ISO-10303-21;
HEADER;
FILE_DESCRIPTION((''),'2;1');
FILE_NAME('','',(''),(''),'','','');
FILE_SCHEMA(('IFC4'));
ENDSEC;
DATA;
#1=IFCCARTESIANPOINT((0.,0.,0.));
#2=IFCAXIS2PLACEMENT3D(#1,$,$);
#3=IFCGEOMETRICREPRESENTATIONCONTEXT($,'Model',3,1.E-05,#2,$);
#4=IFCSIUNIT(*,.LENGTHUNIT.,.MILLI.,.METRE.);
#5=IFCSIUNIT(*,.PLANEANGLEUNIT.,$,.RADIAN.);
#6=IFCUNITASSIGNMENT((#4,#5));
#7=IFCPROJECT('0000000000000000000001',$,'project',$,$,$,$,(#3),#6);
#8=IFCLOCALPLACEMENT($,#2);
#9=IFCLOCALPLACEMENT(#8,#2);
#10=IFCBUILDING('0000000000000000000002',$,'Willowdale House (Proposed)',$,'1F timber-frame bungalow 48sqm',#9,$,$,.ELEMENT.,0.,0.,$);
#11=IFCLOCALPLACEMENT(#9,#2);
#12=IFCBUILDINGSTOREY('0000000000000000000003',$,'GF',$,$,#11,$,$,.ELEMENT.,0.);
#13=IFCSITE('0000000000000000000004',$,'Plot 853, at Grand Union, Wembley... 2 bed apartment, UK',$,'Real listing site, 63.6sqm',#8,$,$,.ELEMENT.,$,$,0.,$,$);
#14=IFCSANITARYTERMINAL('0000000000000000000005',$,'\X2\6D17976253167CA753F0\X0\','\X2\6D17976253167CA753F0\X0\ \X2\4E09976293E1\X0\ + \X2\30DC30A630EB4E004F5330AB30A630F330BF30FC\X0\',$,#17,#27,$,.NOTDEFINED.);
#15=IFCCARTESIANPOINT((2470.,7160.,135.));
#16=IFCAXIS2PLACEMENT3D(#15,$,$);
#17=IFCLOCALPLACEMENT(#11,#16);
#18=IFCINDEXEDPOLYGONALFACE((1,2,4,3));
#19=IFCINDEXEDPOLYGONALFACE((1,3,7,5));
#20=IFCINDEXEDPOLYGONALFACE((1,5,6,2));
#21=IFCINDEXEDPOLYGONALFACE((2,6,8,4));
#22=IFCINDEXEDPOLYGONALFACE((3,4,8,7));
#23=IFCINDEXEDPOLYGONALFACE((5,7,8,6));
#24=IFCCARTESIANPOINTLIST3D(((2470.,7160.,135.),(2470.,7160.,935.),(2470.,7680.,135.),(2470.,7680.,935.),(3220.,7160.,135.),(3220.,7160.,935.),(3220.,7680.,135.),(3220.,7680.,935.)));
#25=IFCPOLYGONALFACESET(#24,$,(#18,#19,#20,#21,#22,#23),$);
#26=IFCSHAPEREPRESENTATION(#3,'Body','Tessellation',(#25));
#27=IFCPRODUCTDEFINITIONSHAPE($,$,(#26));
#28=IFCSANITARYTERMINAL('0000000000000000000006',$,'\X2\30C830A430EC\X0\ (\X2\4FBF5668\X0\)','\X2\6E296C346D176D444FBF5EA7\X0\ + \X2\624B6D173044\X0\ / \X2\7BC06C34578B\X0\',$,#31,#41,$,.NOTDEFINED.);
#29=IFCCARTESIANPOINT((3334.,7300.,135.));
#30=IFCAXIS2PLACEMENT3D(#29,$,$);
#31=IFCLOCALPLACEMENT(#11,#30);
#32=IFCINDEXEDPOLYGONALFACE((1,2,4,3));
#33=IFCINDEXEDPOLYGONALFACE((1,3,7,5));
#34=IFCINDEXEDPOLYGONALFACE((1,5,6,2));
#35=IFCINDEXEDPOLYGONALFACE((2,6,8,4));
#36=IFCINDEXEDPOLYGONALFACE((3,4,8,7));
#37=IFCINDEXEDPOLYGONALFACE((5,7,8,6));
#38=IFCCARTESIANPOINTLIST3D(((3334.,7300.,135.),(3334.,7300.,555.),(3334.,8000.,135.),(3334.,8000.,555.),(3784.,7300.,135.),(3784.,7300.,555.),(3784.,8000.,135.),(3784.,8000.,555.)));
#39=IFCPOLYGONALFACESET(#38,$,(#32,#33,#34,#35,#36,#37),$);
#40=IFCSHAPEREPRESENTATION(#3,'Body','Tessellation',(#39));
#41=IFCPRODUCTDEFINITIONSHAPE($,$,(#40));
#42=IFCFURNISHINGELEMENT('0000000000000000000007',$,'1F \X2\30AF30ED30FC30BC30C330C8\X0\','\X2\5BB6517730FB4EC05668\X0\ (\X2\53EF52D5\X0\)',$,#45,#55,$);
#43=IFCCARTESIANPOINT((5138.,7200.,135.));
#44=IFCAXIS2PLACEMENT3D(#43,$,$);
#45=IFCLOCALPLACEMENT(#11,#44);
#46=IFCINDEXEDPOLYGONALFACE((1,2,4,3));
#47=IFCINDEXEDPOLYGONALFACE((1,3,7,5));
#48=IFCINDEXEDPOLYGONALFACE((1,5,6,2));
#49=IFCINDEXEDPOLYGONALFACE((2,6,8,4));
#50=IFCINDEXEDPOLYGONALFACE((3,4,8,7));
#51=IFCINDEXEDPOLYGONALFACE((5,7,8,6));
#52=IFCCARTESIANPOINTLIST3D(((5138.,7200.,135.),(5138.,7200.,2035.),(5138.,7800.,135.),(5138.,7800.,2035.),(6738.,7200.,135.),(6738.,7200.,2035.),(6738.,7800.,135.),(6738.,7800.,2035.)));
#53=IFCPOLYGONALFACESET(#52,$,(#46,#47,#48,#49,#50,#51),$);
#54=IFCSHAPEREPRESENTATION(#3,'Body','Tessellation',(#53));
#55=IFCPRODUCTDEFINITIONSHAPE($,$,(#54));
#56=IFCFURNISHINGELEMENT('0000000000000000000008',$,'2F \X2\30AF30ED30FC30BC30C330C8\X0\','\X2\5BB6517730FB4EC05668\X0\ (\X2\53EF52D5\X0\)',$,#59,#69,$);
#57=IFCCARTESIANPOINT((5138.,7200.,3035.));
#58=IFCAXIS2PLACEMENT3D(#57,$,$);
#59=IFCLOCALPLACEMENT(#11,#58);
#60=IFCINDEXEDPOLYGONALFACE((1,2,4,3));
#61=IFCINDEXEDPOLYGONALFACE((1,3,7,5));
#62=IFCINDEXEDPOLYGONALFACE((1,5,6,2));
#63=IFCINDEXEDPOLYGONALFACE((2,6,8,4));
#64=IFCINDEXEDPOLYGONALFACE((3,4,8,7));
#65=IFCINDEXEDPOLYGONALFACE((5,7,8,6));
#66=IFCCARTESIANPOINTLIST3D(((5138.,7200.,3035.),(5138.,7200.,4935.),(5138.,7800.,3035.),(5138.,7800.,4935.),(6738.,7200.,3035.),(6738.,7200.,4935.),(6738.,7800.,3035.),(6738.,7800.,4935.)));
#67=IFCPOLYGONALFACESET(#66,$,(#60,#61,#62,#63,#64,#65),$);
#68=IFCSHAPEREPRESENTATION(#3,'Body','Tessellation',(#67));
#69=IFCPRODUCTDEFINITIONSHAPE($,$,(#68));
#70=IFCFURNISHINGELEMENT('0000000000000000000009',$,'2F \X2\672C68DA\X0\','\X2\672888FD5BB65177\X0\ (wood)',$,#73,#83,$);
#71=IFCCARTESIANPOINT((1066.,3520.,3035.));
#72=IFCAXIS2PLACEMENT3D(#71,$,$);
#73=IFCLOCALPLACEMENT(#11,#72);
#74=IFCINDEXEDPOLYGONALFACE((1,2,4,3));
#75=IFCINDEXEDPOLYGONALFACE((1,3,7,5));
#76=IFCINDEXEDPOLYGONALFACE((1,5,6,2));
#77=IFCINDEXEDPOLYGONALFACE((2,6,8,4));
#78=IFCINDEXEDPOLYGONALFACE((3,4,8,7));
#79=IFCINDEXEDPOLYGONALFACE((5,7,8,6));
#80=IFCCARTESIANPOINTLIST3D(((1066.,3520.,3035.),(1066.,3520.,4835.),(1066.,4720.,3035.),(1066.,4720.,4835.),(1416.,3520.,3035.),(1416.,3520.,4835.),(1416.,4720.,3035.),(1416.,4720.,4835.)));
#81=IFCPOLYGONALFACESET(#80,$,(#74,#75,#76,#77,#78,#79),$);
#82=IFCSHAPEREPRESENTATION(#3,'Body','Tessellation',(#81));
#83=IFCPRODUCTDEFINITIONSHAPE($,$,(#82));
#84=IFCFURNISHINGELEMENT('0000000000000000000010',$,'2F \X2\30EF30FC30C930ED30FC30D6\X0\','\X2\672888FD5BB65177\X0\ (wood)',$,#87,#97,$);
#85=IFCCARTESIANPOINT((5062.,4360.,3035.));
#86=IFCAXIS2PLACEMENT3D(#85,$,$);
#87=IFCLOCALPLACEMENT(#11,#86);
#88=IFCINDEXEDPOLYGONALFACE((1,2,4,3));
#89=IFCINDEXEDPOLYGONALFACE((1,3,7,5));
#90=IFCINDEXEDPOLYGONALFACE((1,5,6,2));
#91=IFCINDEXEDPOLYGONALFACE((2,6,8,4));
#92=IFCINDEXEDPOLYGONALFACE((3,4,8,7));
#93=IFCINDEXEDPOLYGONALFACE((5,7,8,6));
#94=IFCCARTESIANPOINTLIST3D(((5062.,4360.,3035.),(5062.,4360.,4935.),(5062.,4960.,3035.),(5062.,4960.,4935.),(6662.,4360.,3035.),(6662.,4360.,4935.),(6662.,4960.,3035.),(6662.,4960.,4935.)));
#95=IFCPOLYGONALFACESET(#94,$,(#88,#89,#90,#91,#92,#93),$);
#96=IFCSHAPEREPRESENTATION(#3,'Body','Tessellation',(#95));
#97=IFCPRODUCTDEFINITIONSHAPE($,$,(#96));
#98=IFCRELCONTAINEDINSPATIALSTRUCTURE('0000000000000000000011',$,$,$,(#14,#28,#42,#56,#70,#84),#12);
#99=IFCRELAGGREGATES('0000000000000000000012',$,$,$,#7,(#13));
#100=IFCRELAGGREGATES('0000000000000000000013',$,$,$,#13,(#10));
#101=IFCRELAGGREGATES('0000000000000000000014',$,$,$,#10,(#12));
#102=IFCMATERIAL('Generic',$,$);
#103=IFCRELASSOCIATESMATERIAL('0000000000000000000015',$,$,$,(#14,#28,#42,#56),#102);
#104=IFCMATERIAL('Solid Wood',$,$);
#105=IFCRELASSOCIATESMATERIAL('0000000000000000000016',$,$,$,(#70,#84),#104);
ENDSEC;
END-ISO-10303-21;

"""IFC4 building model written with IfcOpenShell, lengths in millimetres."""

from ifc_helpers import new_model, si_unit, frame, frame_2d, origin, place, context, project, spatial, rectangle, extrude, material, element, save


model = new_model("IFC4")

# Units and contexts
model_context = context("Model", 3, precision=1e-05, world=origin())
ifc_project = project(units=[si_unit("LENGTHUNIT", "METRE", prefix="MILLI"), si_unit("PLANEANGLEUNIT", "RADIAN")], contexts=[model_context])

# Site, building, storey
site_placement = place(None, origin())
site = spatial("IfcSite", under=ifc_project, at=site_placement, Name="Plot 853, at Grand Union, Wembley... 2 bed apartment, UK", ObjectType="Real listing site, 63.6sqm", CompositionType="ELEMENT", RefElevation=0.0)
building_placement = place(site_placement, origin())
building = spatial("IfcBuilding", under=site, at=building_placement, Name="Willowdale House (Proposed)", ObjectType="1F timber-frame bungalow 48sqm", CompositionType="ELEMENT", ElevationOfRefHeight=0.0, ElevationOfTerrain=0.0)
storey_placement = place(building_placement, origin())
storey = spatial("IfcBuildingStorey", under=building, at=storey_placement, Name="GF", CompositionType="ELEMENT", Elevation=0.0)

# Shared definitions
ifc_material_1 = material(Name="Solid Wood")

# Shared definitions
ifc_material_2 = material(Name="Generic")

# Sanitary terminals
sanitary_terminal_1_placement = place(storey_placement, frame((2470.0, 7160.0, 135.0)))
element("IfcSanitaryTerminal", 1, at=sanitary_terminal_1_placement, inside=storey, material=ifc_material_2, Name="洗面化粧台", Description="洗面化粧台 三面鏡 + ボウル一体カウンター", PredefinedType="NOTDEFINED", context=model_context, shape_type="SweptSolid", body=[
    extrude(rectangle(XDim=750.0, YDim=520.0, at=frame_2d((375.0, 260.0))), frame((2470.0, 7160.0, 135.0)), (0.0, 0.0, 1.0), 800.0),
])
sanitary_terminal_2_placement = place(storey_placement, frame((3334.0, 7300.0, 135.0)))
element("IfcSanitaryTerminal", 2, at=sanitary_terminal_2_placement, inside=storey, material=ifc_material_2, Name="トイレ (便器)", Description="温水洗浄便座 + 手洗い / 節水型", PredefinedType="NOTDEFINED", context=model_context, shape_type="SweptSolid", body=[
    extrude(rectangle(XDim=450.0, YDim=700.0, at=frame_2d((225.0, 350.0))), frame((3334.0, 7300.0, 135.0)), (0.0, 0.0, 1.0), 420.0),
])

# Furnishing elements
furnishing_1_placement = place(storey_placement, frame((5138.0, 7200.0, 135.0)))
element("IfcFurnishingElement", 3, at=furnishing_1_placement, inside=storey, material=ifc_material_2, Name="1F クローゼット", Description="家具・什器 (可動)", context=model_context, shape_type="SweptSolid", body=[
    extrude(rectangle(XDim=1600.0, YDim=600.0, at=frame_2d((800.0, 300.0))), frame((5138.0, 7200.0, 135.0)), (0.0, 0.0, 1.0), 1900.0),
])
furnishing_2_placement = place(storey_placement, frame((5138.0, 7200.0, 3035.0)))
element("IfcFurnishingElement", 4, at=furnishing_2_placement, inside=storey, material=ifc_material_2, Name="2F クローゼット", Description="家具・什器 (可動)", context=model_context, shape_type="SweptSolid", body=[
    extrude(rectangle(XDim=1600.0, YDim=600.0, at=frame_2d((800.0, 300.0))), frame((5138.0, 7200.0, 3035.0)), (0.0, 0.0, 1.0), 1900.0),
])
furnishing_3_placement = place(storey_placement, frame((1066.0, 3520.0, 3035.0)))
element("IfcFurnishingElement", 5, at=furnishing_3_placement, inside=storey, material=ifc_material_1, Name="2F 本棚", Description="木製家具 (wood)", context=model_context, shape_type="SweptSolid", body=[
    extrude(rectangle(XDim=350.0, YDim=1200.0, at=frame_2d((175.0, 600.0))), frame((1066.0, 3520.0, 3035.0)), (0.0, 0.0, 1.0), 1800.0),
])
furnishing_4_placement = place(storey_placement, frame((5062.0, 4360.0, 3035.0)))
element("IfcFurnishingElement", 6, at=furnishing_4_placement, inside=storey, material=ifc_material_1, Name="2F ワードローブ", Description="木製家具 (wood)", context=model_context, shape_type="SweptSolid", body=[
    extrude(rectangle(XDim=1600.0, YDim=600.0, at=frame_2d((800.0, 300.0))), frame((5062.0, 4360.0, 3035.0)), (0.0, 0.0, 1.0), 1900.0),
])

save(model, "model.ifc")
